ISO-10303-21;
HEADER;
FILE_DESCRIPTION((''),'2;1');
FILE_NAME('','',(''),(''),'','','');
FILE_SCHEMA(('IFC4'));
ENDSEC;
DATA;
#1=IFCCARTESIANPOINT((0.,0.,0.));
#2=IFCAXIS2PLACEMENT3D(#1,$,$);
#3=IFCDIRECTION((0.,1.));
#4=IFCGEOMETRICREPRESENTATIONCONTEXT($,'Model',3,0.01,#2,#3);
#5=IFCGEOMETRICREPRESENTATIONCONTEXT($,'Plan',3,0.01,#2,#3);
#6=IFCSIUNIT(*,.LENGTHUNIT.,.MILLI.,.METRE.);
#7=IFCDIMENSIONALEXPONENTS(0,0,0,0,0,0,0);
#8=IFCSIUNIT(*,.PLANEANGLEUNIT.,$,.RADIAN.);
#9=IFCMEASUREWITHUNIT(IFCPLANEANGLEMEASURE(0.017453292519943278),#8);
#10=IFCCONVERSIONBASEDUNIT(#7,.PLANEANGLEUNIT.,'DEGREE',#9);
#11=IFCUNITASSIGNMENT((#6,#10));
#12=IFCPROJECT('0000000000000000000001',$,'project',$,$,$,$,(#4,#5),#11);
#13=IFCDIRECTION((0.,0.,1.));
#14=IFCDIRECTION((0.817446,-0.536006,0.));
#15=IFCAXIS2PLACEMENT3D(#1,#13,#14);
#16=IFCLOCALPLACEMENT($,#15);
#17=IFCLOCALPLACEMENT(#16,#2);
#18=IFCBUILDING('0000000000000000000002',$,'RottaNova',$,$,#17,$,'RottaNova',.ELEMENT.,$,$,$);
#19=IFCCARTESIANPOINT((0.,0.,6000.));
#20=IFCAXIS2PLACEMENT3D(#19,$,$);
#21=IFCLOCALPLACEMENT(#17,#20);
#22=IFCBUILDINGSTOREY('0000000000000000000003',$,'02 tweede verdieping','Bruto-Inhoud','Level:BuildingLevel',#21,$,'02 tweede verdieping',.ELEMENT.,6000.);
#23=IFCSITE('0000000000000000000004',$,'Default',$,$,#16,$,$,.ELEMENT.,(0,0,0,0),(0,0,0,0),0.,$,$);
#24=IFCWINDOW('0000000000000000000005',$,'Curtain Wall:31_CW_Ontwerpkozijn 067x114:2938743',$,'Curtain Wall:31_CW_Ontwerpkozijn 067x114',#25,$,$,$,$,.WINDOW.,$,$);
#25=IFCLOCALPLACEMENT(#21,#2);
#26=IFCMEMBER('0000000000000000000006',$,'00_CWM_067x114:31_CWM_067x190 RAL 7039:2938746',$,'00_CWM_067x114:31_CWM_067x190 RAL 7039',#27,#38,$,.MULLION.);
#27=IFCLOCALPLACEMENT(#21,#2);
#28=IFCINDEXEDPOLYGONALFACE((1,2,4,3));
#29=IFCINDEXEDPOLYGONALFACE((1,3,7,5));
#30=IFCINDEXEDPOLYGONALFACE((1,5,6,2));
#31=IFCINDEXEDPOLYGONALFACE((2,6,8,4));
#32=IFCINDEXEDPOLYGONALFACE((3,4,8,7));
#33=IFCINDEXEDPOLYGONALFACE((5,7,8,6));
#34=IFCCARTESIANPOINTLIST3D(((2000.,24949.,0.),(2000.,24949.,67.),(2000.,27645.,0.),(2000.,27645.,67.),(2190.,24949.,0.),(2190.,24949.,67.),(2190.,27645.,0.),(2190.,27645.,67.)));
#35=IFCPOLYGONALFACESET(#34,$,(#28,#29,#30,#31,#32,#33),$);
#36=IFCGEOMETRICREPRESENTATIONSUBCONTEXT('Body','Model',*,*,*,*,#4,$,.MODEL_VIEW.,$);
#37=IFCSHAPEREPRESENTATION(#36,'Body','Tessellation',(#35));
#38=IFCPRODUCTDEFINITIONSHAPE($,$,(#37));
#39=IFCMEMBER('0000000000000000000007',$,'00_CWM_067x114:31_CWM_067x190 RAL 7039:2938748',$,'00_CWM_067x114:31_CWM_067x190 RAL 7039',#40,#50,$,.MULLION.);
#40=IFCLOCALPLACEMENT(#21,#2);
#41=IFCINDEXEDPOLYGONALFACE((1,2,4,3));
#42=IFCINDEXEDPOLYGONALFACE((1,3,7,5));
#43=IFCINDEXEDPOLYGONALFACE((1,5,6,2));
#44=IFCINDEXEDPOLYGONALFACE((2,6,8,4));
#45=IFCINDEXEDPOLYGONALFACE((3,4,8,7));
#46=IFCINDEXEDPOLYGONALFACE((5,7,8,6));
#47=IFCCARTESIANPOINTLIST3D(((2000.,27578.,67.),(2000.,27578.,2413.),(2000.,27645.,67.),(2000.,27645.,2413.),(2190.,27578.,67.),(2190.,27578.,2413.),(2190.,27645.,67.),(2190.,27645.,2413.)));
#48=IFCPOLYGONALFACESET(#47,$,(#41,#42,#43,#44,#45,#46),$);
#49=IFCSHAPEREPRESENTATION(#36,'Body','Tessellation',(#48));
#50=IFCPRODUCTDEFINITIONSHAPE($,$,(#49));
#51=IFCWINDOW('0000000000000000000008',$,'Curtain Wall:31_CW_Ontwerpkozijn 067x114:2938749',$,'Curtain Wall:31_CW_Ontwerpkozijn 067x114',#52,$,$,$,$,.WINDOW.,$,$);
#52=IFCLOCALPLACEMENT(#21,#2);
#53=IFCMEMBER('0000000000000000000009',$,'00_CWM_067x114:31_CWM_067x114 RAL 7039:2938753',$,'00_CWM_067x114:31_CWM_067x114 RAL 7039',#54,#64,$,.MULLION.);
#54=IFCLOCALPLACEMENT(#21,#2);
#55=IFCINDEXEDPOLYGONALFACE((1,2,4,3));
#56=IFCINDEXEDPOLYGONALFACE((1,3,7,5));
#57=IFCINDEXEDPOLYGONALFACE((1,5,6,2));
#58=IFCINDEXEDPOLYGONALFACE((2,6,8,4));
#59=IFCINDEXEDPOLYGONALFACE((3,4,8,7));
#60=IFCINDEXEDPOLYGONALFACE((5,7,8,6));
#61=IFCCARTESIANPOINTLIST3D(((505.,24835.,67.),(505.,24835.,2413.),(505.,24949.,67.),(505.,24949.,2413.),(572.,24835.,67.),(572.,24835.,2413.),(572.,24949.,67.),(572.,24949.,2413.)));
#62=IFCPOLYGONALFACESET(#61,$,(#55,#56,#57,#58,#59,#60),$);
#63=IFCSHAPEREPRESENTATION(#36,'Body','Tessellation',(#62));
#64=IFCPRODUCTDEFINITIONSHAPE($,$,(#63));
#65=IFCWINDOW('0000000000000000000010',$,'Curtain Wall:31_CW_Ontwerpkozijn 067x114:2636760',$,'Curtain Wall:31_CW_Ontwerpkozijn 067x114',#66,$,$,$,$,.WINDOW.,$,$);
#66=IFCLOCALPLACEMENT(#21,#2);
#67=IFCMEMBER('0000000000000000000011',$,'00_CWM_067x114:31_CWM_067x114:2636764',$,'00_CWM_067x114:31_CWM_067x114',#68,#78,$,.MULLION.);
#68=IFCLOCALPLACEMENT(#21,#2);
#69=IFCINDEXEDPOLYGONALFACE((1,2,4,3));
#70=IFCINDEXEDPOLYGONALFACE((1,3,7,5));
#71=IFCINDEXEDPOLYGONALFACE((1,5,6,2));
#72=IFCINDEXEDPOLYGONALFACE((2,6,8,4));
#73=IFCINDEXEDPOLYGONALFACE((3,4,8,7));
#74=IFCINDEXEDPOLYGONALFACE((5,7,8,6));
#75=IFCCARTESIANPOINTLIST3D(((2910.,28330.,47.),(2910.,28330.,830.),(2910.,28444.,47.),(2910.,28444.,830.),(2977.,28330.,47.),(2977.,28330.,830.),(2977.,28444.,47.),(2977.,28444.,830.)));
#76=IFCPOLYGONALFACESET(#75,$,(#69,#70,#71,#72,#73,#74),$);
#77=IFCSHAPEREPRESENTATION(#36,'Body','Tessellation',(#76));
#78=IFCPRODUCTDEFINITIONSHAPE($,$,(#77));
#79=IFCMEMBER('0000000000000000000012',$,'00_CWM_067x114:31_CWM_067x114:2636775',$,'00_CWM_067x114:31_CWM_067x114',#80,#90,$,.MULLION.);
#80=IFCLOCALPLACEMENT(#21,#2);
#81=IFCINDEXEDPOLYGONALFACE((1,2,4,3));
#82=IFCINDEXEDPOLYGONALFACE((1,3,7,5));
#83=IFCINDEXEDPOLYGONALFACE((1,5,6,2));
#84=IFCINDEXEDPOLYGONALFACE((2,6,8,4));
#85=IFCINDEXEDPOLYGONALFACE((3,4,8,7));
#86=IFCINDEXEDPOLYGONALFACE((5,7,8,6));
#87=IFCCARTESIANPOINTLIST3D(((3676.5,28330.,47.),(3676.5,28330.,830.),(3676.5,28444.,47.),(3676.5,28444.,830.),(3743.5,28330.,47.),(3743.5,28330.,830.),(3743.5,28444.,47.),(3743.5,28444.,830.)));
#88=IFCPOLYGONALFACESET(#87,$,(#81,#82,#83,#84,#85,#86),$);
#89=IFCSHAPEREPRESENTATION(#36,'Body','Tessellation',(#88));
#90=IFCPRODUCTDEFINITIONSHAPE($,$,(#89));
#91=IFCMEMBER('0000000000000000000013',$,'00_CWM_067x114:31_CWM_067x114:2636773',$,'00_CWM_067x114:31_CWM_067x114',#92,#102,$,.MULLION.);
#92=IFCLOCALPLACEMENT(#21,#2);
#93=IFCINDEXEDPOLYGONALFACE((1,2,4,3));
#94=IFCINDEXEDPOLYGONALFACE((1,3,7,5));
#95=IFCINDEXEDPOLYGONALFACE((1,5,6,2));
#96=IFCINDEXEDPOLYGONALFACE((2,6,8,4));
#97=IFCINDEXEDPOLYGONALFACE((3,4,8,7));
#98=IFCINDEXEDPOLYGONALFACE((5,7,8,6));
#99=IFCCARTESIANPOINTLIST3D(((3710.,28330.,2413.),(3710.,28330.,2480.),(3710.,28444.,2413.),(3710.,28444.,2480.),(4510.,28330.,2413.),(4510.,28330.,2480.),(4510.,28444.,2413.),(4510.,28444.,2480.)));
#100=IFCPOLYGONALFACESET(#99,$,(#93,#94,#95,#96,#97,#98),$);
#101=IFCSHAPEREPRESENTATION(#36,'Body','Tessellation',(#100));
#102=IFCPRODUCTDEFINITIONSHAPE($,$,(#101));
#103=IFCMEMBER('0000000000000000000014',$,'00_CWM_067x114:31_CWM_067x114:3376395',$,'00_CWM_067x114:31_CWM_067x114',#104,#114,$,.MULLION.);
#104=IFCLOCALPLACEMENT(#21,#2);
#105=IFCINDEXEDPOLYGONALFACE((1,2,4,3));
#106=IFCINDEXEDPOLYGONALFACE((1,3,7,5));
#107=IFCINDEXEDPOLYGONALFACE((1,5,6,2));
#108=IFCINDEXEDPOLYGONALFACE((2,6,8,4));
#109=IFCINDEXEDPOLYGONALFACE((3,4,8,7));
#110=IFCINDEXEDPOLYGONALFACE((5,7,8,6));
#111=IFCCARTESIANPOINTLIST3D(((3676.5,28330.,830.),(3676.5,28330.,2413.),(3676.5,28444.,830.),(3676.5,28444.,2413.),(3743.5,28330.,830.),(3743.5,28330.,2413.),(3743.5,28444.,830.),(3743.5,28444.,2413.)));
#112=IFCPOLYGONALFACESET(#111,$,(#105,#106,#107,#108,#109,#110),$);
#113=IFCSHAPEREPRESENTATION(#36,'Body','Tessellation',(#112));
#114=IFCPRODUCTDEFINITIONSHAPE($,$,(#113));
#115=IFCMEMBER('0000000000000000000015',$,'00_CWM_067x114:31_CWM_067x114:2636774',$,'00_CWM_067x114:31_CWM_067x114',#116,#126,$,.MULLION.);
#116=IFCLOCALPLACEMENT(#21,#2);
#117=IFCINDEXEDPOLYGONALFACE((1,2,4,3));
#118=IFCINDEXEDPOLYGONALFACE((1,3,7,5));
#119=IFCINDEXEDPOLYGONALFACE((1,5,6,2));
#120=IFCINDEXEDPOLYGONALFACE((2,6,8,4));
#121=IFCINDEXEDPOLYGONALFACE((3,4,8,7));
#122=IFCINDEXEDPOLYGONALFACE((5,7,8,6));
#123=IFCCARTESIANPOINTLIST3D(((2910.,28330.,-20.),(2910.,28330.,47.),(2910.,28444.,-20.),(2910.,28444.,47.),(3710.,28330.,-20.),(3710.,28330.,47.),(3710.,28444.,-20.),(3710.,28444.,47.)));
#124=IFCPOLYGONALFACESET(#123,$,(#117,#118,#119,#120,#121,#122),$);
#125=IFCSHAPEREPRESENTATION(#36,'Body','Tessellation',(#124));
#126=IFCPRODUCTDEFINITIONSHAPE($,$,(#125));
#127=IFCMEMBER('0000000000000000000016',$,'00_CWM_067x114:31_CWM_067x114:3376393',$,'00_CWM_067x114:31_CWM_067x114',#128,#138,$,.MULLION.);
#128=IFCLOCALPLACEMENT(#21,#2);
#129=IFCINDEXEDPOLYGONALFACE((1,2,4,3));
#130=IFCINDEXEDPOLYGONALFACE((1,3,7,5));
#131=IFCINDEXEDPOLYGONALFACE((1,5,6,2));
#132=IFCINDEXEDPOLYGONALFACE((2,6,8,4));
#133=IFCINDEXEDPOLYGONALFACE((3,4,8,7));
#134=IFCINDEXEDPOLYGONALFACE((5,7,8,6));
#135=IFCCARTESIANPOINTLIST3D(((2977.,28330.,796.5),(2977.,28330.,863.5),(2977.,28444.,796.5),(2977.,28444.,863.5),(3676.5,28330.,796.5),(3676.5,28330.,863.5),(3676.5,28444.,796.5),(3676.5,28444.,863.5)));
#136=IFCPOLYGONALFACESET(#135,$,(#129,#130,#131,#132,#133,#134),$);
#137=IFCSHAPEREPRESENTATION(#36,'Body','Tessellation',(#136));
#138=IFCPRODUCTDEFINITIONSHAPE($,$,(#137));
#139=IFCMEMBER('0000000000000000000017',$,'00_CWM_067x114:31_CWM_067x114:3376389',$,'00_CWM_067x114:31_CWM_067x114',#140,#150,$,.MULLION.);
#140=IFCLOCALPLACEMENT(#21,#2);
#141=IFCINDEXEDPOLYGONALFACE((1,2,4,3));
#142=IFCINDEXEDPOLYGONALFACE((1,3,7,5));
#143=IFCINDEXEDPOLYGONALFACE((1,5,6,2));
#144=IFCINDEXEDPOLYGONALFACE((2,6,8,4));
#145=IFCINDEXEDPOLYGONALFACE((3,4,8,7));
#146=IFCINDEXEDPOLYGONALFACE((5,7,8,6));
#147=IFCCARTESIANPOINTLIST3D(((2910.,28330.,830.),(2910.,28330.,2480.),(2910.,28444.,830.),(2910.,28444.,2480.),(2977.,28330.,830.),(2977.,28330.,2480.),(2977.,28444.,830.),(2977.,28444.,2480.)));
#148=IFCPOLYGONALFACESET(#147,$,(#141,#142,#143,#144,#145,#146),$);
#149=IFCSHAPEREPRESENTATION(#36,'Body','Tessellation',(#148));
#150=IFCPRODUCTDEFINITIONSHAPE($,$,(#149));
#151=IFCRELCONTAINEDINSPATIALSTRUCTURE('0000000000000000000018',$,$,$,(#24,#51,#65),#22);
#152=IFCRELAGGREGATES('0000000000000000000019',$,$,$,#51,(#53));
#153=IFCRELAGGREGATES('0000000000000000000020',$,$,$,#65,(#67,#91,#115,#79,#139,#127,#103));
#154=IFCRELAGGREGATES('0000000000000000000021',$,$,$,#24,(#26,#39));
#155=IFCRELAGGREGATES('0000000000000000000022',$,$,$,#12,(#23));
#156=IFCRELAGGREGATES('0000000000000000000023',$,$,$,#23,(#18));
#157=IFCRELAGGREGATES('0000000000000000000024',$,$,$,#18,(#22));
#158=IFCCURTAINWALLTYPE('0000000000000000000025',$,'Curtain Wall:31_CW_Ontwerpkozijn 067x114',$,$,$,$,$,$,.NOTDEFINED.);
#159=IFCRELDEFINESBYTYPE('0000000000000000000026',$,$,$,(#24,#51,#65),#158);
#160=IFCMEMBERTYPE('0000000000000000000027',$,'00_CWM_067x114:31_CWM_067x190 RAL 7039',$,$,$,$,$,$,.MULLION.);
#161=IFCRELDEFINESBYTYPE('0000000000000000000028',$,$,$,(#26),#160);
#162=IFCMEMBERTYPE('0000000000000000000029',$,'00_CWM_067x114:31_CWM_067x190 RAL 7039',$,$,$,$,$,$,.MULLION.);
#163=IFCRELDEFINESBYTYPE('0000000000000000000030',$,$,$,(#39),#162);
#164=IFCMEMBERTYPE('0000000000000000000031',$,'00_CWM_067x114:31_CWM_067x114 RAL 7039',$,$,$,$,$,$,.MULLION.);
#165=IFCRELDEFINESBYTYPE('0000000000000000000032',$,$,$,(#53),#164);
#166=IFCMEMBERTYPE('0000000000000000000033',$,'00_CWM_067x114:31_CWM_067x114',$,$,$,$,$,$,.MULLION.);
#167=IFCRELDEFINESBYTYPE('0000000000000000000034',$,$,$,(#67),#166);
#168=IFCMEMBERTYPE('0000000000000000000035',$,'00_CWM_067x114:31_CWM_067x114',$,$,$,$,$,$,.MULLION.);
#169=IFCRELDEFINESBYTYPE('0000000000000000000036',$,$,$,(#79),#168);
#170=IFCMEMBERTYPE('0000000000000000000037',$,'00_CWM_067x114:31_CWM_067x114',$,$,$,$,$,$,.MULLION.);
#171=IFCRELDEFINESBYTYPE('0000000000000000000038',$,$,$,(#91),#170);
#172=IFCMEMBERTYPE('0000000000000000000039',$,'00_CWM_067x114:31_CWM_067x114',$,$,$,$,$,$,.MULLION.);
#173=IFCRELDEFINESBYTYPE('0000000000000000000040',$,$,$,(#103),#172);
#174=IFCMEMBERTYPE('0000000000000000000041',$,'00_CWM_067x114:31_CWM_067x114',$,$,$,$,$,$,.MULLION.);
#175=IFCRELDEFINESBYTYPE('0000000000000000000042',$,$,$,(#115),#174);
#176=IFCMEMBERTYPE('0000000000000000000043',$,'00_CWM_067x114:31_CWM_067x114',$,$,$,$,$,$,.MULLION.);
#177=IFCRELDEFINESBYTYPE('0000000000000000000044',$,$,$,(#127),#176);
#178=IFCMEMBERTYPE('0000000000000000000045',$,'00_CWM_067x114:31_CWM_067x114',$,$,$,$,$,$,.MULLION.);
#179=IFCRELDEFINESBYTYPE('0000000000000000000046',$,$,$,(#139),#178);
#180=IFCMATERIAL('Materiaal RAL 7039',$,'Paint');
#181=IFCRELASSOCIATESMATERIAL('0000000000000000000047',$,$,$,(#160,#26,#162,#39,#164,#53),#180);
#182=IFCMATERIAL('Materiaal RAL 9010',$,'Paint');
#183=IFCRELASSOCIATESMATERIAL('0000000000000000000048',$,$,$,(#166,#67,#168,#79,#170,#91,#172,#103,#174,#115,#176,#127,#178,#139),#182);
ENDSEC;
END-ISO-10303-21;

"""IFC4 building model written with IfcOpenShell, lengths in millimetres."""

from ifc_helpers import new_model, entity, si_unit, converted_unit, direction, frame, origin, place, context, subcontext, project, spatial, indexed_curve, outline, extrude, source, transform, mapped, material, type_object, type_shapes, element, aggregate, save


model = new_model("IFC4")

# Units and contexts
model_context = context("Model", 3, precision=0.01, world=origin(), true_north=direction((0.0, 1.0)))
plan_context = context("Plan", 3, precision=0.01, world=origin(), true_north=direction((0.0, 1.0)))
body_context = subcontext(model_context, "Body", "Model", "MODEL_VIEW")
ifc_project = project(units=[si_unit("LENGTHUNIT", "METRE", prefix="MILLI"), converted_unit("PLANEANGLEUNIT", "DEGREE", entity("IfcPlaneAngleMeasure", 0.017453292519943278), si_unit("PLANEANGLEUNIT", "RADIAN"), dimensions=[0, 0, 0, 0, 0, 0, 0])], contexts=[model_context, plan_context])

# Site, building, storey
site_placement = place(None, frame((0.0, 0.0, 0.0), z_axis=(0.0, 0.0, 1.0), x_axis=(0.817446, -0.536006, 0.0)))
site = spatial("IfcSite", under=ifc_project, at=site_placement, Name="Default", CompositionType="ELEMENT", RefLatitude=(0, 0, 0, 0), RefLongitude=(0, 0, 0, 0), RefElevation=0.0)
building_placement = place(site_placement, origin())
building = spatial("IfcBuilding", under=site, at=building_placement, Name="RottaNova", LongName="RottaNova", CompositionType="ELEMENT")
storey_placement = place(building_placement, frame((0.0, 0.0, 6000.0)))
storey = spatial("IfcBuildingStorey", under=building, at=storey_placement, Name="02 tweede verdieping", Description="Bruto-Inhoud", ObjectType="Level:BuildingLevel", LongName="02 tweede verdieping", CompositionType="ELEMENT", Elevation=6000.0)

# Window, members
curtain_wall_type = type_object("IfcCurtainWallType", Name="Curtain Wall:31_CW_Ontwerpkozijn 067x114", PredefinedType="NOTDEFINED")
window_1_placement = place(storey_placement, frame((0.0, 0.0, -6000.0)))
window_1 = element("IfcWindow", 1, at=window_1_placement, inside=storey, type_object=curtain_wall_type, Name="Curtain Wall:31_CW_Ontwerpkozijn 067x114:2938743", ObjectType="Curtain Wall:31_CW_Ontwerpkozijn 067x114", PredefinedType="WINDOW")
ifc_material_1 = material(Name="Materiaal RAL 7039", Category="Paint")
member_type_1 = type_object("IfcMemberType", Name="00_CWM_067x114:31_CWM_067x190 RAL 7039", PredefinedType="MULLION", material=ifc_material_1)
shared_shape_1 = source(origin(), body_context, "Body", "SweptSolid", [
    extrude(outline(indexed_curve([(-33.5, -95.0), (33.5, -95.0), (33.5, 95.0), (-33.5, 95.0), (-33.5, -95.0)], self_intersect=False)), frame((-33.5, 95.0, -2696.0), z_axis=(0.0, 0.0, 1.0), x_axis=(-1.0, 0.0, 0.0)), (0.0, 0.0, 1.0), 2696.0),
])
type_shapes(member_type_1, [shared_shape_1])
member_1_placement = place(window_1_placement, frame((2190.0, 27645.0, 6000.0), z_axis=(0.0, 1.0, 0.0), x_axis=(0.0, 0.0, -1.0)))
member_1 = element("IfcMember", 2, at=member_1_placement, type_object=member_type_1, material=ifc_material_1, Name="00_CWM_067x114:31_CWM_067x190 RAL 7039:2938746", ObjectType="00_CWM_067x114:31_CWM_067x190 RAL 7039", PredefinedType="MULLION", context=body_context, shape_type="MappedRepresentation", body=[
    mapped(shared_shape_1, transform((0.0, 0.0, 0.0), scale=1.0)),
])
member_type_2 = type_object("IfcMemberType", Name="00_CWM_067x114:31_CWM_067x190 RAL 7039", PredefinedType="MULLION", material=ifc_material_1)
shared_shape_2 = source(origin(), body_context, "Body", "SweptSolid", [
    extrude(outline(indexed_curve([(-33.5, -95.0), (33.5, -95.0), (33.5, 95.0), (-33.5, 95.0), (-33.5, -95.0)], self_intersect=False)), frame((-33.5, 95.0, -2346.0), z_axis=(0.0, 0.0, 1.0), x_axis=(-1.0, 0.0, 0.0)), (0.0, 0.0, 1.0), 2346.0),
])
type_shapes(member_type_2, [shared_shape_2])
member_2_placement = place(window_1_placement, frame((2190.0, 27645.0, 8413.0), z_axis=(0.0, 0.0, 1.0), x_axis=(0.0, 1.0, 0.0)))
member_2 = element("IfcMember", 3, at=member_2_placement, type_object=member_type_2, material=ifc_material_1, Name="00_CWM_067x114:31_CWM_067x190 RAL 7039:2938748", ObjectType="00_CWM_067x114:31_CWM_067x190 RAL 7039", PredefinedType="MULLION", context=body_context, shape_type="MappedRepresentation", body=[
    mapped(shared_shape_2, transform((0.0, 0.0, 0.0), scale=1.0)),
])

# Window, member
window_2_placement = place(storey_placement, frame((0.0, 0.0, -6000.0)))
window_2 = element("IfcWindow", 4, at=window_2_placement, inside=storey, type_object=curtain_wall_type, Name="Curtain Wall:31_CW_Ontwerpkozijn 067x114:2938749", ObjectType="Curtain Wall:31_CW_Ontwerpkozijn 067x114", PredefinedType="WINDOW")
member_type_3 = type_object("IfcMemberType", Name="00_CWM_067x114:31_CWM_067x114 RAL 7039", PredefinedType="MULLION", material=ifc_material_1)
shared_shape_3 = source(origin(), body_context, "Body", "SweptSolid", [
    extrude(outline(indexed_curve([(-33.5, -57.0), (33.5, -57.0), (33.5, 57.0), (-33.5, 57.0), (-33.5, -57.0)], self_intersect=False)), frame((-33.5, 57.0, -2346.0), z_axis=(0.0, 0.0, 1.0), x_axis=(-1.0, 0.0, 0.0)), (0.0, 0.0, 1.0), 2346.0),
])
type_shapes(member_type_3, [shared_shape_3])
member_3_placement = place(window_2_placement, frame((505.0, 24835.0, 6067.0), z_axis=(0.0, 0.0, -1.0), x_axis=(-1.0, 0.0, 0.0)))
member_3 = element("IfcMember", 5, at=member_3_placement, type_object=member_type_3, material=ifc_material_1, Name="00_CWM_067x114:31_CWM_067x114 RAL 7039:2938753", ObjectType="00_CWM_067x114:31_CWM_067x114 RAL 7039", PredefinedType="MULLION", context=body_context, shape_type="MappedRepresentation", body=[
    mapped(shared_shape_3, transform((0.0, 0.0, 0.0), scale=1.0)),
])

# Window, members
window_3_placement = place(storey_placement, frame((0.0, 0.0, -6000.0)))
window_3 = element("IfcWindow", 6, at=window_3_placement, inside=storey, type_object=curtain_wall_type, Name="Curtain Wall:31_CW_Ontwerpkozijn 067x114:2636760", ObjectType="Curtain Wall:31_CW_Ontwerpkozijn 067x114", PredefinedType="WINDOW")
ifc_material_2 = material(Name="Materiaal RAL 9010", Category="Paint")
member_type_4 = type_object("IfcMemberType", Name="00_CWM_067x114:31_CWM_067x114", PredefinedType="MULLION", material=ifc_material_2)
shared_shape_4 = source(origin(), body_context, "Body", "SweptSolid", [
    extrude(outline(indexed_curve([(-33.5, -57.0), (33.5, -57.0), (33.5, 57.0), (-33.5, 57.0), (-33.5, -57.0)], self_intersect=False)), frame((-33.5, 57.0, -783.0), z_axis=(0.0, 0.0, 1.0), x_axis=(-1.0, 0.0, 0.0)), (0.0, 0.0, 1.0), 783.0),
])
type_shapes(member_type_4, [shared_shape_4])
member_4_placement = place(window_3_placement, frame((2910.0, 28330.0, 6047.0), z_axis=(0.0, 0.0, -1.0), x_axis=(-1.0, 0.0, 0.0)))
member_4 = element("IfcMember", 7, at=member_4_placement, type_object=member_type_4, material=ifc_material_2, Name="00_CWM_067x114:31_CWM_067x114:2636764", ObjectType="00_CWM_067x114:31_CWM_067x114", PredefinedType="MULLION", context=body_context, shape_type="MappedRepresentation", body=[
    mapped(shared_shape_4, transform((0.0, 0.0, 0.0), scale=1.0)),
])
member_type_5 = type_object("IfcMemberType", Name="00_CWM_067x114:31_CWM_067x114", PredefinedType="MULLION", material=ifc_material_2)
shared_shape_5 = source(origin(), body_context, "Body", "SweptSolid", [
    extrude(outline(indexed_curve([(-33.5, -57.0), (33.5, -57.0), (33.5, 57.0), (-33.5, 57.0), (-33.5, -57.0)], self_intersect=False)), frame((0.0, 57.0, -783.0), z_axis=(0.0, 0.0, 1.0), x_axis=(-1.0, 0.0, 0.0)), (0.0, 0.0, 1.0), 783.0),
])
type_shapes(member_type_5, [shared_shape_5])
member_5_placement = place(window_3_placement, frame((3710.0, 28330.0, 6047.0), z_axis=(0.0, 0.0, -1.0), x_axis=(-1.0, 0.0, 0.0)))
member_5 = element("IfcMember", 8, at=member_5_placement, type_object=member_type_5, material=ifc_material_2, Name="00_CWM_067x114:31_CWM_067x114:2636775", ObjectType="00_CWM_067x114:31_CWM_067x114", PredefinedType="MULLION", context=body_context, shape_type="MappedRepresentation", body=[
    mapped(shared_shape_5, transform((0.0, 0.0, 0.0), scale=1.0)),
])
member_type_6 = type_object("IfcMemberType", Name="00_CWM_067x114:31_CWM_067x114", PredefinedType="MULLION", material=ifc_material_2)
shared_shape_6 = source(origin(), body_context, "Body", "SweptSolid", [
    extrude(outline(indexed_curve([(-33.5, -57.0), (33.5, -57.0), (33.5, 57.0), (-33.5, 57.0), (-33.5, -57.0)], self_intersect=False)), frame((-33.5, 57.0, -800.0), z_axis=(0.0, 0.0, 1.0), x_axis=(-1.0, 0.0, 0.0)), (0.0, 0.0, 1.0), 800.0),
])
type_shapes(member_type_6, [shared_shape_6])
member_6_placement = place(window_3_placement, frame((3710.0, 28330.0, 8480.0), z_axis=(-1.0, 0.0, 0.0), x_axis=(0.0, 0.0, 1.0)))
member_6 = element("IfcMember", 9, at=member_6_placement, type_object=member_type_6, material=ifc_material_2, Name="00_CWM_067x114:31_CWM_067x114:2636773", ObjectType="00_CWM_067x114:31_CWM_067x114", PredefinedType="MULLION", context=body_context, shape_type="MappedRepresentation", body=[
    mapped(shared_shape_6, transform((0.0, 0.0, 0.0), scale=1.0)),
])
member_type_7 = type_object("IfcMemberType", Name="00_CWM_067x114:31_CWM_067x114", PredefinedType="MULLION", material=ifc_material_2)
shared_shape_7 = source(origin(), body_context, "Body", "SweptSolid", [
    extrude(outline(indexed_curve([(-33.5, -57.0), (33.5, -57.0), (33.5, 57.0), (-33.5, 57.0), (-33.5, -57.0)], self_intersect=False)), frame((0.0, 57.0, -1583.0), z_axis=(0.0, 0.0, 1.0), x_axis=(-1.0, 0.0, 0.0)), (0.0, 0.0, 1.0), 1583.0),
])
type_shapes(member_type_7, [shared_shape_7])
member_7_placement = place(window_3_placement, frame((3710.0, 28330.0, 6830.0), z_axis=(0.0, 0.0, -1.0), x_axis=(-1.0, 0.0, 0.0)))
member_7 = element("IfcMember", 10, at=member_7_placement, type_object=member_type_7, material=ifc_material_2, Name="00_CWM_067x114:31_CWM_067x114:3376395", ObjectType="00_CWM_067x114:31_CWM_067x114", PredefinedType="MULLION", context=body_context, shape_type="MappedRepresentation", body=[
    mapped(shared_shape_7, transform((0.0, 0.0, 0.0), scale=1.0)),
])
member_type_8 = type_object("IfcMemberType", Name="00_CWM_067x114:31_CWM_067x114", PredefinedType="MULLION", material=ifc_material_2)
shared_shape_8 = source(origin(), body_context, "Body", "SweptSolid", [
    extrude(outline(indexed_curve([(-33.5, -57.0), (33.5, -57.0), (33.5, 57.0), (-33.5, 57.0), (-33.5, -57.0)], self_intersect=False)), frame((-33.5, 57.0, -800.0), z_axis=(0.0, 0.0, 1.0), x_axis=(-1.0, 0.0, 0.0)), (0.0, 0.0, 1.0), 800.0),
])
type_shapes(member_type_8, [shared_shape_8])
member_8_placement = place(window_3_placement, frame((3710.0, 28330.0, 5980.0), z_axis=(1.0, 0.0, 0.0), x_axis=(0.0, 0.0, -1.0)))
member_8 = element("IfcMember", 11, at=member_8_placement, type_object=member_type_8, material=ifc_material_2, Name="00_CWM_067x114:31_CWM_067x114:2636774", ObjectType="00_CWM_067x114:31_CWM_067x114", PredefinedType="MULLION", context=body_context, shape_type="MappedRepresentation", body=[
    mapped(shared_shape_8, transform((0.0, 0.0, 0.0), scale=1.0)),
])
member_type_9 = type_object("IfcMemberType", Name="00_CWM_067x114:31_CWM_067x114", PredefinedType="MULLION", material=ifc_material_2)
shared_shape_9 = source(origin(), body_context, "Body", "SweptSolid", [
    extrude(outline(indexed_curve([(-33.5, -57.0), (33.5, -57.0), (33.5, 57.0), (-33.5, 57.0), (-33.5, -57.0)], self_intersect=False)), frame((0.0, 57.0, -699.5), z_axis=(0.0, 0.0, 1.0), x_axis=(-1.0, 0.0, 0.0)), (0.0, 0.0, 1.0), 699.5),
])
type_shapes(member_type_9, [shared_shape_9])
member_9_placement = place(window_3_placement, frame((2977.0, 28330.0, 6830.0), z_axis=(-1.0, 0.0, 0.0), x_axis=(0.0, 0.0, 1.0)))
member_9 = element("IfcMember", 12, at=member_9_placement, type_object=member_type_9, material=ifc_material_2, Name="00_CWM_067x114:31_CWM_067x114:3376393", ObjectType="00_CWM_067x114:31_CWM_067x114", PredefinedType="MULLION", context=body_context, shape_type="MappedRepresentation", body=[
    mapped(shared_shape_9, transform((0.0, 0.0, 0.0), scale=1.0)),
])
member_type_10 = type_object("IfcMemberType", Name="00_CWM_067x114:31_CWM_067x114", PredefinedType="MULLION", material=ifc_material_2)
shared_shape_10 = source(origin(), body_context, "Body", "SweptSolid", [
    extrude(outline(indexed_curve([(-33.5, -57.0), (33.5, -57.0), (33.5, 57.0), (-33.5, 57.0), (-33.5, -57.0)], self_intersect=False)), frame((-33.5, 57.0, -1650.0), z_axis=(0.0, 0.0, 1.0), x_axis=(-1.0, 0.0, 0.0)), (0.0, 0.0, 1.0), 1650.0),
])
type_shapes(member_type_10, [shared_shape_10])
member_10_placement = place(window_3_placement, frame((2910.0, 28330.0, 6830.0), z_axis=(0.0, 0.0, -1.0), x_axis=(-1.0, 0.0, 0.0)))
member_10 = element("IfcMember", 13, at=member_10_placement, type_object=member_type_10, material=ifc_material_2, Name="00_CWM_067x114:31_CWM_067x114:3376389", ObjectType="00_CWM_067x114:31_CWM_067x114", PredefinedType="MULLION", context=body_context, shape_type="MappedRepresentation", body=[
    mapped(shared_shape_10, transform((0.0, 0.0, 0.0), scale=1.0)),
])

aggregate(window_2, [member_3])

aggregate(window_3, [member_4, member_6, member_8, member_5, member_10, member_9, member_7])

aggregate(window_1, [member_1, member_2])

save(model, "model.ifc")
